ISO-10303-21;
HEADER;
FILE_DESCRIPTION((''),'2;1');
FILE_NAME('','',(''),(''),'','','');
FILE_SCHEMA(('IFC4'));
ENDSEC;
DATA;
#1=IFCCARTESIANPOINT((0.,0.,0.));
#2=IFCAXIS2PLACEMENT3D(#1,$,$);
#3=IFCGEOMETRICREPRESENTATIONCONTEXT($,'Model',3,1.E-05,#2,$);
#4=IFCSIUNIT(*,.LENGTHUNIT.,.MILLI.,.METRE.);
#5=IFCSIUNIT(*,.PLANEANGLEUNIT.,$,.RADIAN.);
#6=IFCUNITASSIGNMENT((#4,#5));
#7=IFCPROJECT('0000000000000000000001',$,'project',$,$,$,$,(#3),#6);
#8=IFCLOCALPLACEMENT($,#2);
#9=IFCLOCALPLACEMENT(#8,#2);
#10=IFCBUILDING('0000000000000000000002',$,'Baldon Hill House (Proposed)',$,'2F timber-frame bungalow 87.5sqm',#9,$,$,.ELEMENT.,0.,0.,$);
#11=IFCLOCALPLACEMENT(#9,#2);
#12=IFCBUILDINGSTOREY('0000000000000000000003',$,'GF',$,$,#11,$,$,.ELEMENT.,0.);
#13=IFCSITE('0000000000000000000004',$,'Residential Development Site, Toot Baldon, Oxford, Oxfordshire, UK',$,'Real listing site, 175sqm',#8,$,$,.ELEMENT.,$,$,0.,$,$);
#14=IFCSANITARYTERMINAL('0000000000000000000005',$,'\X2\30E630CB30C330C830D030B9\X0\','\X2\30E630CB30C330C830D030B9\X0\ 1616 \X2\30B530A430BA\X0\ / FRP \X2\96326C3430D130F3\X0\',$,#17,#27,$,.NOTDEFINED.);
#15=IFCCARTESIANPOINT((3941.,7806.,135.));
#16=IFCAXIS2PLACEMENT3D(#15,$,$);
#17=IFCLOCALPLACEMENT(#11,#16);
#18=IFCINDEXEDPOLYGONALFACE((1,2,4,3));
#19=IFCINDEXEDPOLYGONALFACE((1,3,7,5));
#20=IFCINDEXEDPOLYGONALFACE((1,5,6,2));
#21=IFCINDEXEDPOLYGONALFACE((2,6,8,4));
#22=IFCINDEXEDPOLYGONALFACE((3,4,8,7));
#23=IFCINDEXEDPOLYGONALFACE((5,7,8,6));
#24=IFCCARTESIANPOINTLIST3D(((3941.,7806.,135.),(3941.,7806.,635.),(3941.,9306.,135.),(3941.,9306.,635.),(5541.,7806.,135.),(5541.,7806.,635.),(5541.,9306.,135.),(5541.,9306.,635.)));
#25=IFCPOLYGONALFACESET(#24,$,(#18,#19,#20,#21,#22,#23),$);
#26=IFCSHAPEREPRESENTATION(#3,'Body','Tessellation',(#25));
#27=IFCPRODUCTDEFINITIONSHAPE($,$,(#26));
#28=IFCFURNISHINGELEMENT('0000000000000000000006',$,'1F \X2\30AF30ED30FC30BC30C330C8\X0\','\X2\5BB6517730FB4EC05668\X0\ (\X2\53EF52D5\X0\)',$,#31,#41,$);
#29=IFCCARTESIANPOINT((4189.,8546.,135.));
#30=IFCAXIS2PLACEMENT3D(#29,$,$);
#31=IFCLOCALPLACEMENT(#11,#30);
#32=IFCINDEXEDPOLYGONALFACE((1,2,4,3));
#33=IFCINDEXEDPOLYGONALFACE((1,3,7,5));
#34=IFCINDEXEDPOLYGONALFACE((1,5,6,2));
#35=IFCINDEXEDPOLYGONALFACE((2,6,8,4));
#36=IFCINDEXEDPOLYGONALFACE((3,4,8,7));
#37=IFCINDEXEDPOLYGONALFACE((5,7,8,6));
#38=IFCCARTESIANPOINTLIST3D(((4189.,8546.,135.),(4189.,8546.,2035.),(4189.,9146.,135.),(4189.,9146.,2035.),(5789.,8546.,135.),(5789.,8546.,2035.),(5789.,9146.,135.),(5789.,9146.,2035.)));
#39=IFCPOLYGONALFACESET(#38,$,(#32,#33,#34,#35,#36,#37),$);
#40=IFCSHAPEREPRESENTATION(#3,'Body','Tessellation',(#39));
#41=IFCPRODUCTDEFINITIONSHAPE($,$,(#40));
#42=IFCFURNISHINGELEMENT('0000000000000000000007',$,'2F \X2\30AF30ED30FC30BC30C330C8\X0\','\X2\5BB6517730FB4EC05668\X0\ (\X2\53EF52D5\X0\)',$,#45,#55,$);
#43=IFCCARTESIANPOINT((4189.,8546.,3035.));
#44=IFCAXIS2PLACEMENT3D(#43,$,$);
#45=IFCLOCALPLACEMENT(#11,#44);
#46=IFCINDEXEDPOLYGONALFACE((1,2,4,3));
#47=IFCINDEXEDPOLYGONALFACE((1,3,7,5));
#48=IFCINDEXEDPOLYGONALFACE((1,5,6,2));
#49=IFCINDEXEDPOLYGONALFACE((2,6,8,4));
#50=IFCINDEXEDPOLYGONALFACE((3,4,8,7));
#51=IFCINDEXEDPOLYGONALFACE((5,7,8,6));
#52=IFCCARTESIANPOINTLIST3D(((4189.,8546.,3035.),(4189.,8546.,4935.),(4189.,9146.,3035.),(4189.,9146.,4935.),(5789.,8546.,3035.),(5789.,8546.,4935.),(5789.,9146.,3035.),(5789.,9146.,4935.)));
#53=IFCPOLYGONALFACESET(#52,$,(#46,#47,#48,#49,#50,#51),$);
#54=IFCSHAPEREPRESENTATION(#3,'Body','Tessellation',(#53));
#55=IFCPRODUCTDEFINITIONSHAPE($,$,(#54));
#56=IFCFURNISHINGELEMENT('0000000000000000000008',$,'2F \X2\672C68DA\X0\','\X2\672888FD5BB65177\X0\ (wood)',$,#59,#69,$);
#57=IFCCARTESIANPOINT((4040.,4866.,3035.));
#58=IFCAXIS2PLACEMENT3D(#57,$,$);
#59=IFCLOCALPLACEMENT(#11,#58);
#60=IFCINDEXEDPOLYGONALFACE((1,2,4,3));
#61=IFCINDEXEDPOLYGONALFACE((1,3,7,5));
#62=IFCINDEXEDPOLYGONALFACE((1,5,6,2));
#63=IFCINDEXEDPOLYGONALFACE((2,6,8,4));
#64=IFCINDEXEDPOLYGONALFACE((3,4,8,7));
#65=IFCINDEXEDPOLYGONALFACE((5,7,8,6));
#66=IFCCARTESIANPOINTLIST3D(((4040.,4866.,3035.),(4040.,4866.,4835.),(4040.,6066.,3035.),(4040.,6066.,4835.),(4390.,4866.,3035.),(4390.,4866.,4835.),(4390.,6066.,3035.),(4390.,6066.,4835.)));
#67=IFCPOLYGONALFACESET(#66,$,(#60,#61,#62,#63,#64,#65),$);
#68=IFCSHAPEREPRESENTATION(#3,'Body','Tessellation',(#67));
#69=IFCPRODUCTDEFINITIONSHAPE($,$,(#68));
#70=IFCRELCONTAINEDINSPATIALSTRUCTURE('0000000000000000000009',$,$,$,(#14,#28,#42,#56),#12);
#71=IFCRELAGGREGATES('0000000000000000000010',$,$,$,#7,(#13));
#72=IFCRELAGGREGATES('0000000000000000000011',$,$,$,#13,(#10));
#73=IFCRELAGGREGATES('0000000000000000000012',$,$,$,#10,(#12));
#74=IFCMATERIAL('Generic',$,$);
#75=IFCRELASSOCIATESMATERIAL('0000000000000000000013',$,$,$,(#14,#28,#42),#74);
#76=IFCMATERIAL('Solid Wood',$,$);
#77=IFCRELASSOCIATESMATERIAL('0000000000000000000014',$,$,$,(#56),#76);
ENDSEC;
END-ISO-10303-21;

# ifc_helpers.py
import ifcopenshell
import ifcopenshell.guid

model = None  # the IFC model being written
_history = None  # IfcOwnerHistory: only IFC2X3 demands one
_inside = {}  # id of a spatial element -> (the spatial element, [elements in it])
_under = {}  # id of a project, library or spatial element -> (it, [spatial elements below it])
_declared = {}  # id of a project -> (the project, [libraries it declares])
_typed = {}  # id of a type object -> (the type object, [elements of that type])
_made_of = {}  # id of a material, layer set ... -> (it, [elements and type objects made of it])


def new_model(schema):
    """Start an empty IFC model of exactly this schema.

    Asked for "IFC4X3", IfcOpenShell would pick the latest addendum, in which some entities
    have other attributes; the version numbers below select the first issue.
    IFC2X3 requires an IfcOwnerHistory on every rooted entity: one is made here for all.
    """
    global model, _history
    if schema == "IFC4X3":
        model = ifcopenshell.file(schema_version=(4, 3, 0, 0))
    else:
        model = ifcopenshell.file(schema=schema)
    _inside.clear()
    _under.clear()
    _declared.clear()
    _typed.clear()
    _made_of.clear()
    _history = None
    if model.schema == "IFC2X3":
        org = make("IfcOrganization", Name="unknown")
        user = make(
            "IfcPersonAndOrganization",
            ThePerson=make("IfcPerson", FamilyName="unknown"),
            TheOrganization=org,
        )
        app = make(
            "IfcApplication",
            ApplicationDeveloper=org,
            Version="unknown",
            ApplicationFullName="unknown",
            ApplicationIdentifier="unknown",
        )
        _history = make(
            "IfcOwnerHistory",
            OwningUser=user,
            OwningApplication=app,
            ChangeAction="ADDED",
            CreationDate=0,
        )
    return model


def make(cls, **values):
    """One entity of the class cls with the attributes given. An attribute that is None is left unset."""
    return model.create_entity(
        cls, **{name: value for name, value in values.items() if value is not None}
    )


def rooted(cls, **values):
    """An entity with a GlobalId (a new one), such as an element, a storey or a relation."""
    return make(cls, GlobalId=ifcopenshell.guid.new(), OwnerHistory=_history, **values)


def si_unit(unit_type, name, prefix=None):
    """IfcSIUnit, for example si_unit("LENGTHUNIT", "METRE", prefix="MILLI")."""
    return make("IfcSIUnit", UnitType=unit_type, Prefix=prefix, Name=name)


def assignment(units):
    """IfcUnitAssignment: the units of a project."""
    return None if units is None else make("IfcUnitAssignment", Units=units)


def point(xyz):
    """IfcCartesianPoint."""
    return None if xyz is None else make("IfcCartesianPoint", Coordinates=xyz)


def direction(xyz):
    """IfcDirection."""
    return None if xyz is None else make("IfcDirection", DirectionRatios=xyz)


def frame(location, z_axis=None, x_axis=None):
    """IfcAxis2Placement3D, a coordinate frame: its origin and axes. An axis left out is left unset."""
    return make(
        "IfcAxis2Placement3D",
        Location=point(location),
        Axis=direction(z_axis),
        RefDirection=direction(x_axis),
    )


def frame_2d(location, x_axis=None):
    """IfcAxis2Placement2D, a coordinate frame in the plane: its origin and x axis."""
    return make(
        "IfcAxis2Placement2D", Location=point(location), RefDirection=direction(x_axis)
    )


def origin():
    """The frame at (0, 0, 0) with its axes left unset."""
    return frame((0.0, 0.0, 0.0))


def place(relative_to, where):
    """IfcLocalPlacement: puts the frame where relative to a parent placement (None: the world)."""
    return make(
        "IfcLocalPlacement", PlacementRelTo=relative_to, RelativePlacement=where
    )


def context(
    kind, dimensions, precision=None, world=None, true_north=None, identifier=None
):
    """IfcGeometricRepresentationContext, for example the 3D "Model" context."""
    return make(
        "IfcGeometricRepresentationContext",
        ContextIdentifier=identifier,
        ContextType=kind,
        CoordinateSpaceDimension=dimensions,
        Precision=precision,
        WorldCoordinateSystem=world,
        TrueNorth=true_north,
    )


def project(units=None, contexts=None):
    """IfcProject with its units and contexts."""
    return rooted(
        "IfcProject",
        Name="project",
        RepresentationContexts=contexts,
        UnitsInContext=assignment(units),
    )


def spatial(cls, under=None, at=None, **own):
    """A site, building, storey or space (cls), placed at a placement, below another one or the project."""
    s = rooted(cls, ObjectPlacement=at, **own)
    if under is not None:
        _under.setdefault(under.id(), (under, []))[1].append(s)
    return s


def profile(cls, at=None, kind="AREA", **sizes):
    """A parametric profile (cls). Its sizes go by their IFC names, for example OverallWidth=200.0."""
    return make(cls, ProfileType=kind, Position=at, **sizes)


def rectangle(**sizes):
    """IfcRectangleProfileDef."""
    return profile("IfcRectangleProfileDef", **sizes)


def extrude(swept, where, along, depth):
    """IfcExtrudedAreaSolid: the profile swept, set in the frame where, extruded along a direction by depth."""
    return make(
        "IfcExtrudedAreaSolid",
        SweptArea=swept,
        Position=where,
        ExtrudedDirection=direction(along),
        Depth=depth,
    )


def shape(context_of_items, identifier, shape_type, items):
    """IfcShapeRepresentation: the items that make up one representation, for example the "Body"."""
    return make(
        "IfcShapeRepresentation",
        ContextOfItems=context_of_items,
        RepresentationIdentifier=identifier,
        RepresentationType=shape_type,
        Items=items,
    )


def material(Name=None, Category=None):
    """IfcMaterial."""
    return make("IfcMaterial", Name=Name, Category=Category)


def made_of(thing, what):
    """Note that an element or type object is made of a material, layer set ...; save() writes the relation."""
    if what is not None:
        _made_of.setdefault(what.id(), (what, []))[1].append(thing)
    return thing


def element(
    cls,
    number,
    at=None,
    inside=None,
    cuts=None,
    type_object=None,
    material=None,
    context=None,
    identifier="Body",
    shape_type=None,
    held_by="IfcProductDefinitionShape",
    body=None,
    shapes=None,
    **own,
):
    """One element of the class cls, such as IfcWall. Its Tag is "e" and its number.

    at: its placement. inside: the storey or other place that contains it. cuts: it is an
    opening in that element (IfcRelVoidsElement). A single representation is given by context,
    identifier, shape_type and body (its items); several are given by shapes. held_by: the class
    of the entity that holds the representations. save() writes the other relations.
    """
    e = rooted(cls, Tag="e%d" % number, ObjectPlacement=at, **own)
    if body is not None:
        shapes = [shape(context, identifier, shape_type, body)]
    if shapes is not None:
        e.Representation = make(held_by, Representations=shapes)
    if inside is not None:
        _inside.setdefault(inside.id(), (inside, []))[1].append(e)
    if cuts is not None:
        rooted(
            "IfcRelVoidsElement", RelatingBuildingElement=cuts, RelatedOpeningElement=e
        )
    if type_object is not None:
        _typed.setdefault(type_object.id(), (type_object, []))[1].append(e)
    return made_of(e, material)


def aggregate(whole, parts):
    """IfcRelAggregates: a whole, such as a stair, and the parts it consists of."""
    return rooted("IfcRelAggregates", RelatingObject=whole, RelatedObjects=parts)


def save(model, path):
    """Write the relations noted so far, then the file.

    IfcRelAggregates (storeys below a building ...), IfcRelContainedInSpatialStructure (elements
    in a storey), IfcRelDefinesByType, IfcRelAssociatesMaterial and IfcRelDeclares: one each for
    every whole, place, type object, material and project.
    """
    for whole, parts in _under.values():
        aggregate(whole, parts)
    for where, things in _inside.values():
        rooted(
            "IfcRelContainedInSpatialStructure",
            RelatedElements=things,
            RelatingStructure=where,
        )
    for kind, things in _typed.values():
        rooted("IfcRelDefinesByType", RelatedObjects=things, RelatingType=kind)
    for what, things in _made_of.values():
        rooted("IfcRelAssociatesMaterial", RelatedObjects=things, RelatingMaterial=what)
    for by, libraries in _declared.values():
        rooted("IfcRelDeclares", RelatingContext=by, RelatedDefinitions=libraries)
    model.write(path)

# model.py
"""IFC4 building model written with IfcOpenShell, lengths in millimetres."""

from ifc_helpers import new_model, si_unit, frame, frame_2d, origin, place, context, project, spatial, rectangle, extrude, material, element, save


model = new_model("IFC4")

# Units and contexts
model_context = context("Model", 3, precision=1e-05, world=origin())
ifc_project = project(units=[si_unit("LENGTHUNIT", "METRE", prefix="MILLI"), si_unit("PLANEANGLEUNIT", "RADIAN")], contexts=[model_context])

# Site, building, storey
site_placement = place(None, origin())
site = spatial("IfcSite", under=ifc_project, at=site_placement, Name="Residential Development Site, Toot Baldon, Oxford, Oxfordshire, UK", ObjectType="Real listing site, 175sqm", CompositionType="ELEMENT", RefElevation=0.0)
building_placement = place(site_placement, origin())
building = spatial("IfcBuilding", under=site, at=building_placement, Name="Baldon Hill House (Proposed)", ObjectType="2F timber-frame bungalow 87.5sqm", CompositionType="ELEMENT", ElevationOfRefHeight=0.0, ElevationOfTerrain=0.0)
storey_placement = place(building_placement, origin())
storey = spatial("IfcBuildingStorey", under=building, at=storey_placement, Name="GF", CompositionType="ELEMENT", Elevation=0.0)

# Shared definitions
ifc_material_1 = material(Name="Solid Wood")

# Shared definitions
ifc_material_2 = material(Name="Generic")

# Sanitary terminal
sanitary_terminal_placement = place(storey_placement, frame((3941.0, 7806.0, 135.0)))
element("IfcSanitaryTerminal", 1, at=sanitary_terminal_placement, inside=storey, material=ifc_material_2, Name="ユニットバス", Description="ユニットバス 1616 サイズ / FRP 防水パン", PredefinedType="NOTDEFINED", context=model_context, shape_type="SweptSolid", body=[
    extrude(rectangle(XDim=1600.0, YDim=1500.0, at=frame_2d((800.0, 750.0))), frame((3941.0, 7806.0, 135.0)), (0.0, 0.0, 1.0), 500.0),
])

# Furnishing elements
furnishing_1_placement = place(storey_placement, frame((4189.0, 8546.0, 135.0)))
element("IfcFurnishingElement", 2, at=furnishing_1_placement, inside=storey, material=ifc_material_2, Name="1F クローゼット", Description="家具・什器 (可動)", context=model_context, shape_type="SweptSolid", body=[
    extrude(rectangle(XDim=1600.0, YDim=600.0, at=frame_2d((800.0, 300.0))), frame((4189.0, 8546.0, 135.0)), (0.0, 0.0, 1.0), 1900.0),
])
furnishing_2_placement = place(storey_placement, frame((4189.0, 8546.0, 3035.0)))
element("IfcFurnishingElement", 3, at=furnishing_2_placement, inside=storey, material=ifc_material_2, Name="2F クローゼット", Description="家具・什器 (可動)", context=model_context, shape_type="SweptSolid", body=[
    extrude(rectangle(XDim=1600.0, YDim=600.0, at=frame_2d((800.0, 300.0))), frame((4189.0, 8546.0, 3035.0)), (0.0, 0.0, 1.0), 1900.0),
])
furnishing_3_placement = place(storey_placement, frame((4040.0, 4866.0, 3035.0)))
element("IfcFurnishingElement", 4, at=furnishing_3_placement, inside=storey, material=ifc_material_1, Name="2F 本棚", Description="木製家具 (wood)", context=model_context, shape_type="SweptSolid", body=[
    extrude(rectangle(XDim=350.0, YDim=1200.0, at=frame_2d((175.0, 600.0))), frame((4040.0, 4866.0, 3035.0)), (0.0, 0.0, 1.0), 1800.0),
])

save(model, "model.ifc")
